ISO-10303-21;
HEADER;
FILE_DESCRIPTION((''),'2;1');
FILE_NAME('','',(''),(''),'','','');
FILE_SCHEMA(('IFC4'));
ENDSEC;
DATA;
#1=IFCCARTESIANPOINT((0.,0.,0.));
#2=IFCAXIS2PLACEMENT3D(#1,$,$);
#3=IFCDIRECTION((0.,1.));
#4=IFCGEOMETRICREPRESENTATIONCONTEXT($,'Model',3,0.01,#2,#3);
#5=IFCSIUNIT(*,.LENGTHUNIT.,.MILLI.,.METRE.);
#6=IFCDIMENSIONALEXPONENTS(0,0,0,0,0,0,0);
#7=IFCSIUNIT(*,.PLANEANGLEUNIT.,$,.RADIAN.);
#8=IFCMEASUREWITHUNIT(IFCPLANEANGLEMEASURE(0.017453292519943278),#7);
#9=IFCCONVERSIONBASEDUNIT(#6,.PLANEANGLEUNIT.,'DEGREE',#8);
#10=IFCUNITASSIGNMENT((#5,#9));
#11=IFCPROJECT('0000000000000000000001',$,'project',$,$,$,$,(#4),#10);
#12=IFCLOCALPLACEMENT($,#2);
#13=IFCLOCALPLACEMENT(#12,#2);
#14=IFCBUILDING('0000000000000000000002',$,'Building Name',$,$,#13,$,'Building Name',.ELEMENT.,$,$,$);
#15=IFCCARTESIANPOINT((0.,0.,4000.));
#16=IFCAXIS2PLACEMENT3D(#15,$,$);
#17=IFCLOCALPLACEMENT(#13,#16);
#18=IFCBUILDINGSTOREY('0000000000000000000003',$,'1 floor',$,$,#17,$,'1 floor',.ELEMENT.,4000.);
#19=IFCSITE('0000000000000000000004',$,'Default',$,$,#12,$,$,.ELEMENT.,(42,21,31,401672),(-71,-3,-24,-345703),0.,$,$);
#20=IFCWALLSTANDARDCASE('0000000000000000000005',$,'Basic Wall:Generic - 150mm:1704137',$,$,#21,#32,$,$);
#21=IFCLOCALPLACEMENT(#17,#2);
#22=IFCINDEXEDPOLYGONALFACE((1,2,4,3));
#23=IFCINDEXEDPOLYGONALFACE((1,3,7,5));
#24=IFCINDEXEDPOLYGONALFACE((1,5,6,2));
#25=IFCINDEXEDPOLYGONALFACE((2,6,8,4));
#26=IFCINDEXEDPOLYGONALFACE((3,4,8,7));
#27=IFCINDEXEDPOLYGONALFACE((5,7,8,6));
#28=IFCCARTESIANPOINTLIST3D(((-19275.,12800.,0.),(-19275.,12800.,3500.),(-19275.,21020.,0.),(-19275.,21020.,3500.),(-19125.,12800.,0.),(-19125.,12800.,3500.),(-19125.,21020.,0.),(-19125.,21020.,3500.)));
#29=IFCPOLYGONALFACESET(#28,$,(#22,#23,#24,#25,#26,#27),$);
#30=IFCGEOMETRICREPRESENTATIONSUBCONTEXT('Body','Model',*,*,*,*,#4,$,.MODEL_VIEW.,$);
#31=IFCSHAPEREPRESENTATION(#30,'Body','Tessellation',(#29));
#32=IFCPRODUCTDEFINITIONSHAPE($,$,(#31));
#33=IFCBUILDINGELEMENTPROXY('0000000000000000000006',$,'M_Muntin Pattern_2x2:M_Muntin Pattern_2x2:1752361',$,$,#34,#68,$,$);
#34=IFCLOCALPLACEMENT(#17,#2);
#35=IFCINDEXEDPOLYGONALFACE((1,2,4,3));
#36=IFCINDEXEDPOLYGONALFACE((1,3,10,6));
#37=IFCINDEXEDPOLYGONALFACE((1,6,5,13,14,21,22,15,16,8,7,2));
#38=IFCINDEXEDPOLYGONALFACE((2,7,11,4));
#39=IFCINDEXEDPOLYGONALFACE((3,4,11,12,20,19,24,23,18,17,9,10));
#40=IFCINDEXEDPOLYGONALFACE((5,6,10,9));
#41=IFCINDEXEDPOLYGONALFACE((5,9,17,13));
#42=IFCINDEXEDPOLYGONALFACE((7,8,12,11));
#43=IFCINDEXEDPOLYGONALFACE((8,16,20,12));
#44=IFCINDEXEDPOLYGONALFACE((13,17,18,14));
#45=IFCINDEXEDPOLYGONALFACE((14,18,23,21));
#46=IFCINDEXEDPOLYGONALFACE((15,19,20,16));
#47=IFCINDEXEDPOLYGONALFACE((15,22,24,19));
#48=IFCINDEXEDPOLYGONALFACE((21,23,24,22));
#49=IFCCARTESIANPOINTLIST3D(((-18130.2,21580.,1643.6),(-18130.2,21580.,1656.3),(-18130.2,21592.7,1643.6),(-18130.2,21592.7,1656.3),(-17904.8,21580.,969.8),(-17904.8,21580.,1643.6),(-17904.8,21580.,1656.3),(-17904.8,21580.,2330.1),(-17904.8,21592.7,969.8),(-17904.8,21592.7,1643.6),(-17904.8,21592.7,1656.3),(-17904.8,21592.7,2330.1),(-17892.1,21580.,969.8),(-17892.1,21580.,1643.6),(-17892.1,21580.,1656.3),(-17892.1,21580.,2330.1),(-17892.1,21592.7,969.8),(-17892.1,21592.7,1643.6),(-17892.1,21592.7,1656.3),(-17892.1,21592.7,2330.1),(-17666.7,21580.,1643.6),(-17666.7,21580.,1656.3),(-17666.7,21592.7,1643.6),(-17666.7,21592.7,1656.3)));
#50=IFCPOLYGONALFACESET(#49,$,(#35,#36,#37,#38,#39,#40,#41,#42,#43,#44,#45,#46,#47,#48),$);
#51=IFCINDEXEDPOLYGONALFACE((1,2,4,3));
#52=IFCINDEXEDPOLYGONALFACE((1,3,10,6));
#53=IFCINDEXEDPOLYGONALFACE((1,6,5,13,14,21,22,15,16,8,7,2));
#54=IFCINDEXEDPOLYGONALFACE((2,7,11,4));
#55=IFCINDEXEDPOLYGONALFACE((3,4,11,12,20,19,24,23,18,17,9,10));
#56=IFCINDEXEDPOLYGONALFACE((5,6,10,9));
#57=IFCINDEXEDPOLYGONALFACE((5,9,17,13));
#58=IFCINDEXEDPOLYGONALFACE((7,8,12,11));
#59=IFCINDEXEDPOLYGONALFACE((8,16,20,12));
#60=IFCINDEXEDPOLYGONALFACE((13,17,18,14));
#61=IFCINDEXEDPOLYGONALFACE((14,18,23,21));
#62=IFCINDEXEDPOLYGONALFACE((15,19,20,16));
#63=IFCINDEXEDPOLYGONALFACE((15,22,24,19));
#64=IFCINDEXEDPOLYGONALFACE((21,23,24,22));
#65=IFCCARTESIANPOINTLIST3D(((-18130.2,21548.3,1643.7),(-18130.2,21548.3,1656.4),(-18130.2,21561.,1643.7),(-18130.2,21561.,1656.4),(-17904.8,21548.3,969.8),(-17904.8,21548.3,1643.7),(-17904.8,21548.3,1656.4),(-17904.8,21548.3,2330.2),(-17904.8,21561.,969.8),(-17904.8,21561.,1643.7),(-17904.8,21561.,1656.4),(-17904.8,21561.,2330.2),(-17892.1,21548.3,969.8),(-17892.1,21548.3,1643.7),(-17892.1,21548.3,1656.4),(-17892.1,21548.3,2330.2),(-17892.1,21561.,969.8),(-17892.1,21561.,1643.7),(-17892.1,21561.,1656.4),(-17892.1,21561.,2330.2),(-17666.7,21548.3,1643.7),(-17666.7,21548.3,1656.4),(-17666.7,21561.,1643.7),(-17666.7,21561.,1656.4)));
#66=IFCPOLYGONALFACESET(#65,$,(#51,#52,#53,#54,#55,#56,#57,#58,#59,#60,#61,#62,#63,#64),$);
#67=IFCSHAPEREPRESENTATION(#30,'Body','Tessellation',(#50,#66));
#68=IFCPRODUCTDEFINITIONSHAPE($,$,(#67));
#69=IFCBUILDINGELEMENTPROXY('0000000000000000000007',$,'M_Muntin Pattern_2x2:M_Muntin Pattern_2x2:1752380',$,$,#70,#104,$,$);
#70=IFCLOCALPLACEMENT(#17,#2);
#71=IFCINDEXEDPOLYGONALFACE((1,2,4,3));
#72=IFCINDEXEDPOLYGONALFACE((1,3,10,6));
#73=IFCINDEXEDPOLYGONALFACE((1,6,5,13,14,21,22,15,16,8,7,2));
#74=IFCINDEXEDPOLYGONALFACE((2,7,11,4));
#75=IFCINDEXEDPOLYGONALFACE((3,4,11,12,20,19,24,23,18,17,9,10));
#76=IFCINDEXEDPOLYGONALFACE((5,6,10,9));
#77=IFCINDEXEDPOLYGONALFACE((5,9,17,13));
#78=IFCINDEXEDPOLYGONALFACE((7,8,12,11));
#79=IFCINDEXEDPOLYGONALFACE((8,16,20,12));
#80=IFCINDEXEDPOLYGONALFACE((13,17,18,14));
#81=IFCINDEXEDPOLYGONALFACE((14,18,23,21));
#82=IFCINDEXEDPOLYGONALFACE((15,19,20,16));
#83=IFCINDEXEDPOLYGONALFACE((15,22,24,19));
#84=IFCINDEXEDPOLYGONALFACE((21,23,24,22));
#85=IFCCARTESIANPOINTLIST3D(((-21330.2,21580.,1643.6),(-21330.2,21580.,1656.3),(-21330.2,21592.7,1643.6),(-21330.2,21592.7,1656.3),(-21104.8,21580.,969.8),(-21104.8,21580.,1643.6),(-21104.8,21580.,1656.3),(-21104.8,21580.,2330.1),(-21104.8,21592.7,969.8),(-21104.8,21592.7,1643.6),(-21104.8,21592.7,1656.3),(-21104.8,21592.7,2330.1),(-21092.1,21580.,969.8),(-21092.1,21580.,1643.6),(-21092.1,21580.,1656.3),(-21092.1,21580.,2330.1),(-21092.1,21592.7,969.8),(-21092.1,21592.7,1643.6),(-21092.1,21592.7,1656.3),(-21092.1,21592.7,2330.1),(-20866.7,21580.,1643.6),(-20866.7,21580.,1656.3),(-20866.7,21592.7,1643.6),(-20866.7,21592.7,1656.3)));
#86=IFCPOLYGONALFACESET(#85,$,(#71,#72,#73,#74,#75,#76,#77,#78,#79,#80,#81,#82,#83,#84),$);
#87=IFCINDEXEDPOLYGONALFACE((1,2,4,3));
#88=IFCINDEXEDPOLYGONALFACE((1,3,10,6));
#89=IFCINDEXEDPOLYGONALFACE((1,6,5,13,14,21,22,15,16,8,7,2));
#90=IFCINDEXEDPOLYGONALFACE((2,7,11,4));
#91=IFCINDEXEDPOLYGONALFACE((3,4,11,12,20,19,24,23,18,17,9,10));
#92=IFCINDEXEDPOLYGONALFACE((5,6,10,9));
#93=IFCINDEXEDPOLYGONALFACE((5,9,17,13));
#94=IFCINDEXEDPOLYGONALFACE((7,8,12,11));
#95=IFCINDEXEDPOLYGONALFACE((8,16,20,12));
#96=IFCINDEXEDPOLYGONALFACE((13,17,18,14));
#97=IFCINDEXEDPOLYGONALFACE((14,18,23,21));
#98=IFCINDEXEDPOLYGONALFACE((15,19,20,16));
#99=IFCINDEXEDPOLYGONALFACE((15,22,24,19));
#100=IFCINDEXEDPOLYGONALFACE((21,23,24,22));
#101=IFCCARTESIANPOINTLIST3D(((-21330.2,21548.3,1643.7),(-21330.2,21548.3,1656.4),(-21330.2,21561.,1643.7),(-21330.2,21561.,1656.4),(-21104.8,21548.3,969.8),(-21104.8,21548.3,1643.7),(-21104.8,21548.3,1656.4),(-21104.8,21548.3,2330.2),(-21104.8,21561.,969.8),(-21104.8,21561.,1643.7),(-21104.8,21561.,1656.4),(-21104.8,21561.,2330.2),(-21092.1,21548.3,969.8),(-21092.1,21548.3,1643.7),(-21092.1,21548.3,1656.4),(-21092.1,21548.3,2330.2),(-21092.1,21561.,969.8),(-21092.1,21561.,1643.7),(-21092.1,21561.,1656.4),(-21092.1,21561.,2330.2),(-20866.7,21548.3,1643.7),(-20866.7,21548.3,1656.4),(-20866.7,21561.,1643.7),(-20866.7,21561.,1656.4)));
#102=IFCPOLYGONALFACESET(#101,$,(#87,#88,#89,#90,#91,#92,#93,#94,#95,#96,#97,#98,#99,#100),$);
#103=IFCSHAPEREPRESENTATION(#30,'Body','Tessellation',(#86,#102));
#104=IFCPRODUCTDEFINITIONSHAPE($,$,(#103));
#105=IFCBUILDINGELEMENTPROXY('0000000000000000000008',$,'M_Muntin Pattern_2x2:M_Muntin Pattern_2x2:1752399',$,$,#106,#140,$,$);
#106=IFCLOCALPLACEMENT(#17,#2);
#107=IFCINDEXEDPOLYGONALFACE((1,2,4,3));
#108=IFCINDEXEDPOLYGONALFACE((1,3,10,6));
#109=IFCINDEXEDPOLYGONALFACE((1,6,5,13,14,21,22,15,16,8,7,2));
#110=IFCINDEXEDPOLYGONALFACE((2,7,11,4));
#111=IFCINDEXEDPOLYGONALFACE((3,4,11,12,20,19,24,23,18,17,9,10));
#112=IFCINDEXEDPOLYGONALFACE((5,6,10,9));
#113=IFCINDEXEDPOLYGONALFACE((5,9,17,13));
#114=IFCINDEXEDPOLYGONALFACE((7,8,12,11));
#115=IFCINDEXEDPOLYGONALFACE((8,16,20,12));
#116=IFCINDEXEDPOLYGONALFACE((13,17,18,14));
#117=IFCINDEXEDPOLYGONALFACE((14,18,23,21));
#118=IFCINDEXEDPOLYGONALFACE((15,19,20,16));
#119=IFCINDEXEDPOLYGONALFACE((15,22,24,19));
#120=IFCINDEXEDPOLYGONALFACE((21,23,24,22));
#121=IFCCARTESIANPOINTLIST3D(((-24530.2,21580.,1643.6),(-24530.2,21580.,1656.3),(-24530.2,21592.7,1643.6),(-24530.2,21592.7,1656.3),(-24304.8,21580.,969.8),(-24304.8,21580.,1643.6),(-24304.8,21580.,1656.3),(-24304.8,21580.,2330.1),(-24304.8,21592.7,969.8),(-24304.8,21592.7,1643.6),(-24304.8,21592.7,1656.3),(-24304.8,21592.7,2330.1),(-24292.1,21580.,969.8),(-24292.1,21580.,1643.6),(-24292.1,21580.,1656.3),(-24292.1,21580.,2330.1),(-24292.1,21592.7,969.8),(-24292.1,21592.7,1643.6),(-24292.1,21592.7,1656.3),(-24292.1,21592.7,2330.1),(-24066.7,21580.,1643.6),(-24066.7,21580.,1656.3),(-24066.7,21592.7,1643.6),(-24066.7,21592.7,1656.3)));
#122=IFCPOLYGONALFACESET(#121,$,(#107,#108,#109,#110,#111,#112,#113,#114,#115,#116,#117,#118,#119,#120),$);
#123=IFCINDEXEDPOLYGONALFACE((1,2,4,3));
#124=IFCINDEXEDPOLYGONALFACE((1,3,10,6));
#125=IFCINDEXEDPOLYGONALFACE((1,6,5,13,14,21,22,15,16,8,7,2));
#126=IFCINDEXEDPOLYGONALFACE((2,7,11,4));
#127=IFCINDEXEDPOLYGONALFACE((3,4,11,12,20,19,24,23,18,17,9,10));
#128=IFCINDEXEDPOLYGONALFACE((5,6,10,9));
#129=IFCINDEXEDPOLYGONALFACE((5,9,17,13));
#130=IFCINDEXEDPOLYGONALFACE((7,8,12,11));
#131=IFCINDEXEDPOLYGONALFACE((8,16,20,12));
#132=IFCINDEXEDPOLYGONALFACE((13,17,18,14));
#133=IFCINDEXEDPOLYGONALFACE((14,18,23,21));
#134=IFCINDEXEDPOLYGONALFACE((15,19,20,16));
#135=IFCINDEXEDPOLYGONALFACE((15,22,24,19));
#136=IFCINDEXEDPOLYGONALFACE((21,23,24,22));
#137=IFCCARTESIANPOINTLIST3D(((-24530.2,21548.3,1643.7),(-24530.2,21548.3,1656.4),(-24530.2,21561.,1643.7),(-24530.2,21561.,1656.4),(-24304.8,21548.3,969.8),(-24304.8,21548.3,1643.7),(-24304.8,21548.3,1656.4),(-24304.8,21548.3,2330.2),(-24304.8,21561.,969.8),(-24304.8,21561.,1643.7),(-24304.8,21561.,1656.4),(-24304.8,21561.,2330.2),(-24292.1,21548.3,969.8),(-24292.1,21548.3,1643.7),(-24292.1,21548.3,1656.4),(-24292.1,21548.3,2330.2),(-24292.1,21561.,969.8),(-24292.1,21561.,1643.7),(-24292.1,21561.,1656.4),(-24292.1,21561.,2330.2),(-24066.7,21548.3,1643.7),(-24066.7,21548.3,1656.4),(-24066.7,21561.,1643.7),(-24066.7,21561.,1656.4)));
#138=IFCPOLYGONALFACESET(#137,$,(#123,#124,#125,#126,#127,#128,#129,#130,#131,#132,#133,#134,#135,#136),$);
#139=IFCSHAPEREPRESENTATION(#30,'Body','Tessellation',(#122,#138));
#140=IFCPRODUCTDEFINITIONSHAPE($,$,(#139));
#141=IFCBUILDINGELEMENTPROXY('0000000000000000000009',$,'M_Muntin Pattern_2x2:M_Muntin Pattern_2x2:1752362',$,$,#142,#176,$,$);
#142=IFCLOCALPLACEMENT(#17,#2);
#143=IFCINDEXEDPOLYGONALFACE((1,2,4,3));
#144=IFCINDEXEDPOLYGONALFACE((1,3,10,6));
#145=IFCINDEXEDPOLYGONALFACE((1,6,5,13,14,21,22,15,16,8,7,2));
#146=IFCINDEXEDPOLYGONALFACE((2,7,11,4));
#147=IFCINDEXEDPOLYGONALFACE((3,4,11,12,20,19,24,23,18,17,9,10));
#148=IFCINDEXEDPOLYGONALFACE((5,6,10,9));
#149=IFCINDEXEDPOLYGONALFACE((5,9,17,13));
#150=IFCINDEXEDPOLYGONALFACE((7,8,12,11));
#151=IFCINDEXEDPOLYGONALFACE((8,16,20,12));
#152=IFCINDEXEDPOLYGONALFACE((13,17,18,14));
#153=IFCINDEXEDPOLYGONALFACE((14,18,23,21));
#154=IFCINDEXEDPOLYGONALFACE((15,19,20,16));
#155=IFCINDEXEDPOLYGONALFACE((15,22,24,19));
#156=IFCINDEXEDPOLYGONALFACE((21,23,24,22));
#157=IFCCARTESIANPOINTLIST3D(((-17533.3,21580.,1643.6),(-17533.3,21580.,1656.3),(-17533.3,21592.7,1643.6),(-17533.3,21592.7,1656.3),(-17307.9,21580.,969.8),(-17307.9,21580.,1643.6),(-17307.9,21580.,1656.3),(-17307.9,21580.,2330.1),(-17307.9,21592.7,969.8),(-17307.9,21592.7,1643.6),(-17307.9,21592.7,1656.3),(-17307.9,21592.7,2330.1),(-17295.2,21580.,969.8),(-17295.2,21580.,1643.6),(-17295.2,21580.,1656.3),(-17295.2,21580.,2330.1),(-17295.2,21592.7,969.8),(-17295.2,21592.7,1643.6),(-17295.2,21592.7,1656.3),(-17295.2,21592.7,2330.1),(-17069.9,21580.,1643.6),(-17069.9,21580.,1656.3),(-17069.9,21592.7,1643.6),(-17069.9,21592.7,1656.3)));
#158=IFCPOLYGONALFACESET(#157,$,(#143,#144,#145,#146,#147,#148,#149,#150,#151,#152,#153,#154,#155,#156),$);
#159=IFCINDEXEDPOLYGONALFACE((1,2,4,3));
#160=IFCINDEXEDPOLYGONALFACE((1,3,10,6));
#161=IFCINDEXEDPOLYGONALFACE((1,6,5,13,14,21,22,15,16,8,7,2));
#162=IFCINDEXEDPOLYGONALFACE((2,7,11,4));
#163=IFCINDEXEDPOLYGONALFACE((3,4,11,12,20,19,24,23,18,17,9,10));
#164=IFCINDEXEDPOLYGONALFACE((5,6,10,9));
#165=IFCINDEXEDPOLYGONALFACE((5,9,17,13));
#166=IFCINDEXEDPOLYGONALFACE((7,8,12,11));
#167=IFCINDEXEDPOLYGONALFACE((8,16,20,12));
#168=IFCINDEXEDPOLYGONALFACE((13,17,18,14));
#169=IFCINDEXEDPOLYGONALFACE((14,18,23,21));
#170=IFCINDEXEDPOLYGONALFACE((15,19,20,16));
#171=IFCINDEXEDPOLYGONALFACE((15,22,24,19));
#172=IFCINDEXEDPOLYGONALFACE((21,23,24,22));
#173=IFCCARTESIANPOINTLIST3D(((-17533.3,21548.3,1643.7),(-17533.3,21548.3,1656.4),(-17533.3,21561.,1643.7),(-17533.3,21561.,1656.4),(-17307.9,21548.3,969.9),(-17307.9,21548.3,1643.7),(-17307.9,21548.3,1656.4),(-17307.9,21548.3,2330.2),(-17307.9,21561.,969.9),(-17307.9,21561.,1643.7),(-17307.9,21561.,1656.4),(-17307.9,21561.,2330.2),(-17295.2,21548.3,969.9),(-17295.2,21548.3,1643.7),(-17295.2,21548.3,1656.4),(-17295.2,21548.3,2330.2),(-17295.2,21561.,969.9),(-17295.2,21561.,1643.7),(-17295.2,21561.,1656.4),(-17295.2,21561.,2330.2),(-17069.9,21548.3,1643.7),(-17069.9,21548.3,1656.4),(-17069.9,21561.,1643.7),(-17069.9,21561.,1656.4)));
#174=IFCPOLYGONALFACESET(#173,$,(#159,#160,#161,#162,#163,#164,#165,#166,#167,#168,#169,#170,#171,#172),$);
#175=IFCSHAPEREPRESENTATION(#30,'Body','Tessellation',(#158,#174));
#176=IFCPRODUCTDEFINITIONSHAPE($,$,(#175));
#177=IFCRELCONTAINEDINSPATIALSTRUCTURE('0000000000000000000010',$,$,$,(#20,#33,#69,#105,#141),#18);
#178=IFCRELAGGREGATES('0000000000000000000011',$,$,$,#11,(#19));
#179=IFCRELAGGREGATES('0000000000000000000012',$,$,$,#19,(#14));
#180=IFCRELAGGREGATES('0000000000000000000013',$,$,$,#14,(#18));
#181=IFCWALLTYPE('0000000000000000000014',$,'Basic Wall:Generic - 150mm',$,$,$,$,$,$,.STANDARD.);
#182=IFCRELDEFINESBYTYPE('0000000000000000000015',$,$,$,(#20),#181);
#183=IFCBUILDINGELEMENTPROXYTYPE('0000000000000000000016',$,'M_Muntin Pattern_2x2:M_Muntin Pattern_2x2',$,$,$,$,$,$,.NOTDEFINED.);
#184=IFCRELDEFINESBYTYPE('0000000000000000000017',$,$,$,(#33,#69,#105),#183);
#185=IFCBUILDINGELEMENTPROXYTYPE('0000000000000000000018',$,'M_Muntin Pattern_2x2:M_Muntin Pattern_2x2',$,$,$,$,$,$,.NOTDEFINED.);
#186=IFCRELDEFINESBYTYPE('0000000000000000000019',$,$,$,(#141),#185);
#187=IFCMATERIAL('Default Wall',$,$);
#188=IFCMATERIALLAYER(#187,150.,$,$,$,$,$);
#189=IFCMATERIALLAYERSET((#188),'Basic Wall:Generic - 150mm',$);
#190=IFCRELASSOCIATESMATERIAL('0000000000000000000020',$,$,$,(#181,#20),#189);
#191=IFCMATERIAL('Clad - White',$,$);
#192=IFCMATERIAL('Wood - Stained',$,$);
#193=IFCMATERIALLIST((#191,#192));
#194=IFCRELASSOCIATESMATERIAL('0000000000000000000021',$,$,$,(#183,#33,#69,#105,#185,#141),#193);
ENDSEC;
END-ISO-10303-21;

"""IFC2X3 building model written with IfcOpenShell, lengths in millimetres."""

from ifc_helpers import new_model, entity, si_unit, converted_unit, direction, frame, frame_2d, origin, place, context, subcontext, project, spatial, polyline, rectangle, outline, extrude, source, transform, mapped, material, material_list, layer, layer_set, layer_usage, type_object, type_shapes, element, save


model = new_model("IFC2X3")

# Units and contexts
model_context = context("Model", 3, precision=0.01, world=origin(), true_north=direction((0.0, 1.0)))
body_context = subcontext(model_context, "Body", "Model", "MODEL_VIEW")
ifc_project = project(units=[si_unit("LENGTHUNIT", "METRE", prefix="MILLI"), converted_unit("PLANEANGLEUNIT", "DEGREE", entity("IfcPlaneAngleMeasure", 0.017453292519943278), si_unit("PLANEANGLEUNIT", "RADIAN"), dimensions=[0, 0, 0, 0, 0, 0, 0])], contexts=[model_context])

# Site, building, storey
site_placement = place(None, origin())
site = spatial("IfcSite", under=ifc_project, at=site_placement, Name="Default", CompositionType="ELEMENT", RefLatitude=(42, 21, 31, 401672), RefLongitude=(-71, -3, -24, -345703), RefElevation=0.0)
building_placement = place(site_placement, origin())
building = spatial("IfcBuilding", under=site, at=building_placement, Name="Building Name", LongName="Building Name", CompositionType="ELEMENT")
storey_placement = place(building_placement, frame((0.0, 0.0, 4000.0)))
storey = spatial("IfcBuildingStorey", under=building, at=storey_placement, Name="1 floor", LongName="1 floor", CompositionType="ELEMENT", Elevation=4000.0)

# Wall
ifc_material_1 = material(Name="Default Wall")
ifc_layer = layer(ifc_material_1, 150.0)
ifc_layer_set = layer_set([ifc_layer], Name="Basic Wall:Generic - 150mm")
ifc_layer_usage = layer_usage(ifc_layer_set, "AXIS2", "NEGATIVE", 75.0)
wall_type = type_object("IfcWallType", Name="Basic Wall:Generic - 150mm", PredefinedType="STANDARD", material=ifc_layer_set)
wall_placement = place(storey_placement, frame((-19200.0, 21020.0, 0.0), z_axis=(0.0, 0.0, 1.0), x_axis=(0.0, -1.0, 0.0)))
element("IfcWallStandardCase", 1, at=wall_placement, inside=storey, type_object=wall_type, material=ifc_layer_usage, Name="Basic Wall:Generic - 150mm:1704137", context=body_context, shape_type="SweptSolid", body=[
    extrude(rectangle(XDim=8220.0, YDim=150.0, at=frame_2d((4110.0, 0.0), x_axis=(-1.0, 0.0))), origin(), (0.0, 0.0, 1.0), 3500.0),
])

# Building element proxies
ifc_material_2 = material(Name="Clad - White")
ifc_material_3 = material(Name="Wood - Stained")
ifc_material_list = material_list([ifc_material_2, ifc_material_3])
building_element_proxy_type_1 = type_object("IfcBuildingElementProxyType", Name="M_Muntin Pattern_2x2:M_Muntin Pattern_2x2", PredefinedType="NOTDEFINED", material=ifc_material_list)
shared_shape_1 = source(origin(), body_context, "Body", "SweptSolid", [
    extrude(outline(polyline([(6.4, -6.4), (680.1, -6.4), (680.1, 6.3), (6.4, 6.3), (6.4, 231.7), (-6.3, 231.7), (-6.3, 6.3), (-680.2, 6.3), (-680.2, -6.4), (-6.3, -6.4), (-6.3, -231.7), (6.4, -231.7), (6.4, -6.4)])), frame((0.0, 9.5, 680.1), z_axis=(0.0, 1.0, 0.0), x_axis=(0.0, 0.0, 1.0)), (0.0, 0.0, 1.0), 12.7),
    extrude(outline(polyline([(6.4, -6.4), (680.2, -6.4), (680.2, 6.3), (6.4, 6.3), (6.4, 231.7), (-6.3, 231.7), (-6.3, 6.3), (-680.2, 6.3), (-680.2, -6.4), (-6.3, -6.4), (-6.3, -231.7), (6.4, -231.7), (6.4, -6.4)])), frame((0.0, -22.2, 680.2), z_axis=(0.0, 1.0, 0.0), x_axis=(0.0, 0.0, 1.0)), (0.0, 0.0, 1.0), 12.7),
])
type_shapes(building_element_proxy_type_1, [shared_shape_1])
for number, where, name in (
    (2, (-17898.4, 21570.5, 969.8), "M_Muntin Pattern_2x2:M_Muntin Pattern_2x2:1752361"),
    (3, (-21098.4, 21570.5, 969.8), "M_Muntin Pattern_2x2:M_Muntin Pattern_2x2:1752380"),
    (4, (-24298.4, 21570.5, 969.8), "M_Muntin Pattern_2x2:M_Muntin Pattern_2x2:1752399"),
):
    element("IfcBuildingElementProxy", number, at=place(storey_placement, frame(where)), inside=storey, type_object=building_element_proxy_type_1, material=ifc_material_list, Name=name, context=body_context, shape_type="MappedRepresentation", body=[
        mapped(shared_shape_1, transform((0.0, 0.0, 0.0), scale=1.0)),
    ])
building_element_proxy_type_2 = type_object("IfcBuildingElementProxyType", Name="M_Muntin Pattern_2x2:M_Muntin Pattern_2x2", PredefinedType="NOTDEFINED", material=ifc_material_list)
shared_shape_2 = source(origin(), body_context, "Body", "SweptSolid", [
    extrude(outline(polyline([(6.4, -6.4), (680.1, -6.4), (680.1, 6.3), (6.4, 6.3), (6.4, 231.7), (-6.3, 231.7), (-6.3, 6.3), (-680.2, 6.3), (-680.2, -6.4), (-6.3, -6.4), (-6.3, -231.7), (6.4, -231.7), (6.4, -6.4)])), frame((0.0, -22.2, 680.1), z_axis=(0.0, 1.0, 0.0), x_axis=(0.0, 0.0, 1.0)), (0.0, 0.0, 1.0), 12.7),
    extrude(outline(polyline([(6.4, -6.4), (680.2, -6.4), (680.2, 6.3), (6.4, 6.3), (6.4, 231.7), (-6.3, 231.7), (-6.3, 6.3), (-680.2, 6.3), (-680.2, -6.4), (-6.3, -6.4), (-6.3, -231.7), (6.4, -231.7), (6.4, -6.4)])), frame((0.0, 9.5, 680.2), z_axis=(0.0, 1.0, 0.0), x_axis=(0.0, 0.0, 1.0)), (0.0, 0.0, 1.0), 12.7),
])
type_shapes(building_element_proxy_type_2, [shared_shape_2])
for number, where, z_axis, x_axis, name in (
    (5, (-17301.6, 21570.5, 969.9), (0.0, 0.0, 1.0), (-1.0, 0.0, 0.0), "M_Muntin Pattern_2x2:M_Muntin Pattern_2x2:1752362"),
):
    element("IfcBuildingElementProxy", number, at=place(storey_placement, frame(where, z_axis=z_axis, x_axis=x_axis)), inside=storey, type_object=building_element_proxy_type_2, material=ifc_material_list, Name=name, context=body_context, shape_type="MappedRepresentation", body=[
        mapped(shared_shape_2, transform((0.0, 0.0, 0.0), scale=1.0)),
    ])

save(model, "model.ifc")
